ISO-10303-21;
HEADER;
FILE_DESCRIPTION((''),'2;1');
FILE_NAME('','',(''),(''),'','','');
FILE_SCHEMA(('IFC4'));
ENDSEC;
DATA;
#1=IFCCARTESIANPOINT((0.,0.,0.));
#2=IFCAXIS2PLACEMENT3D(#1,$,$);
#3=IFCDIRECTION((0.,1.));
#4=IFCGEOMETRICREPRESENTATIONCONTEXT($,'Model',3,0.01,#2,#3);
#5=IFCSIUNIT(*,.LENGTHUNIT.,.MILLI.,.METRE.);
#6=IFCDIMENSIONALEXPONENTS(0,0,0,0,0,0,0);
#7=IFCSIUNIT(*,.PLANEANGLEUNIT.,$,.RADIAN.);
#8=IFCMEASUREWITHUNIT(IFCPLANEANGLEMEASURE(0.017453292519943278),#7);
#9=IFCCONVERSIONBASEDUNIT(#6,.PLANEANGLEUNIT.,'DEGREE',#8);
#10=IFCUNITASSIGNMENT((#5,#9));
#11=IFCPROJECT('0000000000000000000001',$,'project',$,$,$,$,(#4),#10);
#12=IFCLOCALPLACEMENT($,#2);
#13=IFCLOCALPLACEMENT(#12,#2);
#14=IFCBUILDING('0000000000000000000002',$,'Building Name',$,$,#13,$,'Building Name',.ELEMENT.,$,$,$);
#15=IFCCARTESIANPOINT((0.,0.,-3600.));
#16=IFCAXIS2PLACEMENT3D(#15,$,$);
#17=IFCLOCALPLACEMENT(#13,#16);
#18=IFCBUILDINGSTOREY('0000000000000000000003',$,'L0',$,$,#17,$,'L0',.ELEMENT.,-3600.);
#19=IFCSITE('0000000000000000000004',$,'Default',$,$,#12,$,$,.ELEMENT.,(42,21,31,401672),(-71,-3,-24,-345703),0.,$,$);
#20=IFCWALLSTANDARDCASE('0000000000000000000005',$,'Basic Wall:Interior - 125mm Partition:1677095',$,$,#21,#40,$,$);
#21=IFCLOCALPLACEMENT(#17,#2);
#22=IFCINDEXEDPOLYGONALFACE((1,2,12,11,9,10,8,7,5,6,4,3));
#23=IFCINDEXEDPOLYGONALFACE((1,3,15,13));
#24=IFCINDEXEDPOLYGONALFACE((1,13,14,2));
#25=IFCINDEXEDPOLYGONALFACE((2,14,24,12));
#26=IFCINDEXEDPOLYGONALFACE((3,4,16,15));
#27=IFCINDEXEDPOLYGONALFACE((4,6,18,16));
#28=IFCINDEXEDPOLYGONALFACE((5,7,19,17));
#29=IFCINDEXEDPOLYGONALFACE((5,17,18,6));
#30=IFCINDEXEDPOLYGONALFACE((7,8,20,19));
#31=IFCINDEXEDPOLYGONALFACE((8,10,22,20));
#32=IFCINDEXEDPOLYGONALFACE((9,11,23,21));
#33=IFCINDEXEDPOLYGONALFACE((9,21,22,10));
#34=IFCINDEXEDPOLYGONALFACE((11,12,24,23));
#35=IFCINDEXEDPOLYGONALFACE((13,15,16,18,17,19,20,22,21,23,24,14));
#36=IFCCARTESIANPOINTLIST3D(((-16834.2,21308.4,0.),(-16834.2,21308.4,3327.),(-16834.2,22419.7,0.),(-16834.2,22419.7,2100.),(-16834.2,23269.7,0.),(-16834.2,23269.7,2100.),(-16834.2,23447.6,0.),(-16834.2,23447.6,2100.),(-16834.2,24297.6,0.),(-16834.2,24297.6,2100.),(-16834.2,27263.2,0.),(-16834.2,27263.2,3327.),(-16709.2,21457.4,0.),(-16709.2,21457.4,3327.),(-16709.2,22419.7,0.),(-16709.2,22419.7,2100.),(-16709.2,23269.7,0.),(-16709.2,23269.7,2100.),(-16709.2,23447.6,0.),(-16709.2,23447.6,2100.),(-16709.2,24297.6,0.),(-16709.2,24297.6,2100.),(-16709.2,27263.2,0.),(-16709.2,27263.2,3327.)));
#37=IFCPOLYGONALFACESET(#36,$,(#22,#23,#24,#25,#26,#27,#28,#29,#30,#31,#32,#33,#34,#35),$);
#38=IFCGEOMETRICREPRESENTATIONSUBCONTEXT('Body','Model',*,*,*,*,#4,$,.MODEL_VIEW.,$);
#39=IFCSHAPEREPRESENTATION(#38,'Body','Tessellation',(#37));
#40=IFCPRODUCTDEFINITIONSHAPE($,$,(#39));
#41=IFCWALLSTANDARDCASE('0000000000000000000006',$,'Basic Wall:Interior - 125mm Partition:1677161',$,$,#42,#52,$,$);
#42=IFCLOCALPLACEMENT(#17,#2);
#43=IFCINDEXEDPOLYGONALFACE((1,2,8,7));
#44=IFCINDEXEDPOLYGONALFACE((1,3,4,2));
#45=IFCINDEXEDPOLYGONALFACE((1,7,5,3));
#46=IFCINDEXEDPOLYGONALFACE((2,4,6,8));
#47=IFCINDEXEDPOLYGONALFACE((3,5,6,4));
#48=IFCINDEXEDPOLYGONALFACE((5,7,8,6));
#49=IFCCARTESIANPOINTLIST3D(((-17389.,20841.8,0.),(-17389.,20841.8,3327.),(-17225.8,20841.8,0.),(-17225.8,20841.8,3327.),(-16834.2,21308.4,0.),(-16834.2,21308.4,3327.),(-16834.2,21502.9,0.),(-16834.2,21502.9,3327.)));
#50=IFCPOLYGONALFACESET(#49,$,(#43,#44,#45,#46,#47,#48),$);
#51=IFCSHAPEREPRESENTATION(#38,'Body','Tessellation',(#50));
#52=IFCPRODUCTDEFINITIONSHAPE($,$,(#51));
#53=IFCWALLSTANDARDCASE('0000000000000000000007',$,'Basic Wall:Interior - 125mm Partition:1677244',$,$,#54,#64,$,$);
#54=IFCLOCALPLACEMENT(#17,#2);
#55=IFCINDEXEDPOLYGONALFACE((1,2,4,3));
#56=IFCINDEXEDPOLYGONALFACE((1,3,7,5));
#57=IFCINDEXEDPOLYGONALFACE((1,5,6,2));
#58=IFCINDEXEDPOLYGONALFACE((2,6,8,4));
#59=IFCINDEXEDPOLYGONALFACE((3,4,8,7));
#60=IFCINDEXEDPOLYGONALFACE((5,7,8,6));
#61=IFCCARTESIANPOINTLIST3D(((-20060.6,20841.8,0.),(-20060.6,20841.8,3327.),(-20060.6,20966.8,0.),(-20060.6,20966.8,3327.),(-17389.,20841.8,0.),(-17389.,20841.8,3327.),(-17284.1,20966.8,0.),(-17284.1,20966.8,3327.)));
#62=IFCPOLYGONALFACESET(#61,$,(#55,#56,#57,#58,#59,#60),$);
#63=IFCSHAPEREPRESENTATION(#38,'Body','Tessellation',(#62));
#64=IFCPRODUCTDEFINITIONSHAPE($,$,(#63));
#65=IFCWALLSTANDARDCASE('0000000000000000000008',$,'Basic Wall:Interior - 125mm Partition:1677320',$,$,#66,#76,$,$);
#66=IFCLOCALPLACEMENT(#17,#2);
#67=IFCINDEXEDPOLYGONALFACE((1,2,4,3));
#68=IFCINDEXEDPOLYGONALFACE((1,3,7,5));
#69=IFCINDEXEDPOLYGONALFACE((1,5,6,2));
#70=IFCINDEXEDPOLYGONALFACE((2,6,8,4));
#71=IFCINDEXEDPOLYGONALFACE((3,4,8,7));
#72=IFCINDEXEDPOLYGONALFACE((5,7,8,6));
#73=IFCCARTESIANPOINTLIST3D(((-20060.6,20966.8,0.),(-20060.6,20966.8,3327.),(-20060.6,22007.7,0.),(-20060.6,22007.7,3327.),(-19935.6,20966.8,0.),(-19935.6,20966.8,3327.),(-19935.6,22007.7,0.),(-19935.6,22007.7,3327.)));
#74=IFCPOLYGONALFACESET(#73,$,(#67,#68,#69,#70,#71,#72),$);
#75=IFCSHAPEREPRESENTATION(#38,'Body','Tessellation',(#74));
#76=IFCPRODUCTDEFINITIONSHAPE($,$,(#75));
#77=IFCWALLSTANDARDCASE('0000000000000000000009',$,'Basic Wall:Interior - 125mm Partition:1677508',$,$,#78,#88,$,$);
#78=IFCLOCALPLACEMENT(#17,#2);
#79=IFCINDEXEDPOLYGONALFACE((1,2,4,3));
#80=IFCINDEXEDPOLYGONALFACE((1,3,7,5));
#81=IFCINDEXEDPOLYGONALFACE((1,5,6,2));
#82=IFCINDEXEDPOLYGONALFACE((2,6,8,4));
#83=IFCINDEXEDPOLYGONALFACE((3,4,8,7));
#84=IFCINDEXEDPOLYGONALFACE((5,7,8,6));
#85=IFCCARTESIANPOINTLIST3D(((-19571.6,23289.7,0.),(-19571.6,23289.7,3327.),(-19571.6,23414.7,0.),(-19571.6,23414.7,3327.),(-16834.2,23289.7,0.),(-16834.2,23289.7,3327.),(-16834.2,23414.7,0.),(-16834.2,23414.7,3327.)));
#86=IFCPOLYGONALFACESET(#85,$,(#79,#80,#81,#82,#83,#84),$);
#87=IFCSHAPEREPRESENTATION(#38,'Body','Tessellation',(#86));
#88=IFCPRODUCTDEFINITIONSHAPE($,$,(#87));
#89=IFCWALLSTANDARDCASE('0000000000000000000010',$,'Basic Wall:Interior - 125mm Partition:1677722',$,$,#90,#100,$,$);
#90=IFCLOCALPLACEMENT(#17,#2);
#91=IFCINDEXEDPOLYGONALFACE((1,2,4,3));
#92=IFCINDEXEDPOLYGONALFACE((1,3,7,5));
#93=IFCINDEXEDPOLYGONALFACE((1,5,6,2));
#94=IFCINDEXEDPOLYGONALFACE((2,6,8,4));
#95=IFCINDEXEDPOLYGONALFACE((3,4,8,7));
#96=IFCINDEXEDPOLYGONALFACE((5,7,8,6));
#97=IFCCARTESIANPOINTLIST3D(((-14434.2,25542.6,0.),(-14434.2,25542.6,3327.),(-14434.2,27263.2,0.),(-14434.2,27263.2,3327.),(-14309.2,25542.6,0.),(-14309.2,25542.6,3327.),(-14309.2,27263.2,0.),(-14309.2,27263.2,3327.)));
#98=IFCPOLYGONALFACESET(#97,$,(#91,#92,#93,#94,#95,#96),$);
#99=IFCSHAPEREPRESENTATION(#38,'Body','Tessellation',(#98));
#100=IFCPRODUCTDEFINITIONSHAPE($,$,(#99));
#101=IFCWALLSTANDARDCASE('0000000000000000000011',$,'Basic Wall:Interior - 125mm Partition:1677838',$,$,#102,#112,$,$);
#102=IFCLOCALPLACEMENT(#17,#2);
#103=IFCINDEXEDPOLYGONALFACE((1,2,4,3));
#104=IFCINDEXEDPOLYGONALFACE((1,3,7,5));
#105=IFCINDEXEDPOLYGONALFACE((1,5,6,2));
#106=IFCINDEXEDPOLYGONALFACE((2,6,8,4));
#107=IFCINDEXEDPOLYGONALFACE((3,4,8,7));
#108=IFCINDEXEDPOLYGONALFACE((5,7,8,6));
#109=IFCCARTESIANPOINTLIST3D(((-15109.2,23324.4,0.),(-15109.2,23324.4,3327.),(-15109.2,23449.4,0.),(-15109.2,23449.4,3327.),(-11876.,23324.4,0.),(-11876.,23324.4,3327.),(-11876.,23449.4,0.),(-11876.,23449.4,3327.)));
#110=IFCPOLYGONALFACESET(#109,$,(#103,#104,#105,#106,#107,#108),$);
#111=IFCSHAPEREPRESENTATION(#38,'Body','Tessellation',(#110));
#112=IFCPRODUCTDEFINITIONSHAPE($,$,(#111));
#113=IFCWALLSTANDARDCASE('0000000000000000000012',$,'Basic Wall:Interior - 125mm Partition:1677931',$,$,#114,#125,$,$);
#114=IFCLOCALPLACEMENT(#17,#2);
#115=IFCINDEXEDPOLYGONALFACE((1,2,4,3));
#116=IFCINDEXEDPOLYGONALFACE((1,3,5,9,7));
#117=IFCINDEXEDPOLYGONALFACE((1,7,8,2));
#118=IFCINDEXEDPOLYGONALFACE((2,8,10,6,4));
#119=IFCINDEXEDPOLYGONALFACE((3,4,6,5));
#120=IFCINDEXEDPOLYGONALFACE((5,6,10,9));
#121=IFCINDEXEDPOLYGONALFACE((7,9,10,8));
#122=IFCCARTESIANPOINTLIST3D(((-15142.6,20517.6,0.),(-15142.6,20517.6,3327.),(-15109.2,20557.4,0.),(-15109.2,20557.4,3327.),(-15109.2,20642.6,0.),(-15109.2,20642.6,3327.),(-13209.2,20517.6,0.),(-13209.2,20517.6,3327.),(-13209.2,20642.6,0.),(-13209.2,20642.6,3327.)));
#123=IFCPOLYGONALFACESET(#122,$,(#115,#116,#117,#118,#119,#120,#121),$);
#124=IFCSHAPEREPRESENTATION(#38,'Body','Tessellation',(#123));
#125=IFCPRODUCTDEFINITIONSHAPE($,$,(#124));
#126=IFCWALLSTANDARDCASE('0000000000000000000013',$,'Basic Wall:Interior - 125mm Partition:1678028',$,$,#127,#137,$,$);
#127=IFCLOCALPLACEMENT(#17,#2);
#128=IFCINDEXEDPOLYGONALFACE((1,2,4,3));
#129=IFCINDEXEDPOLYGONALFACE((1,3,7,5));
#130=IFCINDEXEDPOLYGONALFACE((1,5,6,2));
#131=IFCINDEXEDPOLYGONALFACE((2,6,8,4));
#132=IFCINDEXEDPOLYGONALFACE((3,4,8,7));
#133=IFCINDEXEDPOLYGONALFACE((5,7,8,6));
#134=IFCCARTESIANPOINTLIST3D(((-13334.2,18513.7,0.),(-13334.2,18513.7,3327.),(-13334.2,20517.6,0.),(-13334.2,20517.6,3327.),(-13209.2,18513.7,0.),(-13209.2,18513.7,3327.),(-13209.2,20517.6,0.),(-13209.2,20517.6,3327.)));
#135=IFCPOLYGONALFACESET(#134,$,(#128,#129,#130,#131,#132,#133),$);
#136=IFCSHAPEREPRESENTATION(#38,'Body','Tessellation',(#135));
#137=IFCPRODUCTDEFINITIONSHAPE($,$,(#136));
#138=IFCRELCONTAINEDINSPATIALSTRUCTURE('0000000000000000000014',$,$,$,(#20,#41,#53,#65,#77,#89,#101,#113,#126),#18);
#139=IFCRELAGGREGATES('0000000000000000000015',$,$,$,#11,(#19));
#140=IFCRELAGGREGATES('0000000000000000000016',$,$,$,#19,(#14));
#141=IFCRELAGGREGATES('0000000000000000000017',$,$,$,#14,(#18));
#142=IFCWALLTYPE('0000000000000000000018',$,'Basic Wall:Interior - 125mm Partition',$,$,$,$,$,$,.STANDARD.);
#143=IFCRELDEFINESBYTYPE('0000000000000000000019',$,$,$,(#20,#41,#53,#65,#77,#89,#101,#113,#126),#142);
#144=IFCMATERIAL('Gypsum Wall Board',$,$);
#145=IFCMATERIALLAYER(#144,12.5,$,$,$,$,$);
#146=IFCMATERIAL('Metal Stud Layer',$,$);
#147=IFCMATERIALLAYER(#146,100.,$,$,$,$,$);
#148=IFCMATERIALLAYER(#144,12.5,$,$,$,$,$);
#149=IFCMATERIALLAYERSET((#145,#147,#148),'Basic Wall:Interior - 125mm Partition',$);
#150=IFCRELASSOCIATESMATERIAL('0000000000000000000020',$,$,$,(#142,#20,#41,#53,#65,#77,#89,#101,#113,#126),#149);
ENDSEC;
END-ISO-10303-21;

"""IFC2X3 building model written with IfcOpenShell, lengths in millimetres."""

from ifc_helpers import new_model, entity, si_unit, converted_unit, direction, frame, frame_2d, origin, place, context, subcontext, project, spatial, polyline, rectangle, outline, extrude, clip, bounded_halfspace, material, layer, layer_set, layer_usage, type_object, element, save


model = new_model("IFC2X3")

# Units and contexts
model_context = context("Model", 3, precision=0.01, world=origin(), true_north=direction((0.0, 1.0)))
body_context = subcontext(model_context, "Body", "Model", "MODEL_VIEW")
ifc_project = project(units=[si_unit("LENGTHUNIT", "METRE", prefix="MILLI"), converted_unit("PLANEANGLEUNIT", "DEGREE", entity("IfcPlaneAngleMeasure", 0.017453292519943278), si_unit("PLANEANGLEUNIT", "RADIAN"), dimensions=[0, 0, 0, 0, 0, 0, 0])], contexts=[model_context])

# Site, building, storey
site_placement = place(None, origin())
site = spatial("IfcSite", under=ifc_project, at=site_placement, Name="Default", CompositionType="ELEMENT", RefLatitude=(42, 21, 31, 401672), RefLongitude=(-71, -3, -24, -345703), RefElevation=0.0)
building_placement = place(site_placement, origin())
building = spatial("IfcBuilding", under=site, at=building_placement, Name="Building Name", LongName="Building Name", CompositionType="ELEMENT")
storey_placement = place(building_placement, frame((0.0, 0.0, -3600.0)))
storey = spatial("IfcBuildingStorey", under=building, at=storey_placement, Name="L0", LongName="L0", CompositionType="ELEMENT", Elevation=-3600.0)

# Shared definitions
ifc_material_1 = material(Name="Gypsum Wall Board")

# Shared definitions
ifc_layer_1 = layer(ifc_material_1, 12.5)
ifc_material_2 = material(Name="Metal Stud Layer")
ifc_layer_2 = layer(ifc_material_2, 100.0)
ifc_layer_3 = layer(ifc_material_1, 12.5)
ifc_layer_set_1 = layer_set([ifc_layer_1, ifc_layer_2, ifc_layer_3], Name="Basic Wall:Interior - 125mm Partition")
wall_type_1 = type_object("IfcWallType", Name="Basic Wall:Interior - 125mm Partition", PredefinedType="STANDARD", material=ifc_layer_set_1)

# Wall, openings
ifc_layer_usage_1 = layer_usage(ifc_layer_set_1, "AXIS2", "NEGATIVE", 62.5)
wall_1_placement = place(storey_placement, frame((-16771.7, 27263.2, 0.0), z_axis=(0.0, 0.0, 1.0), x_axis=(0.0, -1.0, 0.0)))
wall_1 = element("IfcWallStandardCase", 1, at=wall_1_placement, inside=storey, type_object=wall_type_1, material=ifc_layer_usage_1, Name="Basic Wall:Interior - 125mm Partition:1677095", context=body_context, shape_type="Clipping", body=[
    clip(extrude(outline(polyline([(0.0, -62.5), (3848.5, -62.5), (3973.5, -62.5), (5760.3, -62.5), (5954.8, -62.5), (5805.8, 62.5), (1845.5, 62.5), (1720.5, 62.5), (0.0, 62.5), (0.0, -62.5)])), origin(), (0.0, 0.0, 1.0), 3327.0), bounded_halfspace(frame((0.0, -62.5, 3327.0), z_axis=(0.0, 0.0, -1.0), x_axis=(-1.0, 0.0, 0.0)), True, frame((0.0, -62.5, 3327.0)), polyline([(0.0, 0.0), (3848.5, 0.0), (3973.5, 0.0), (5760.3, 0.0), (5954.8, 0.0), (5805.8, 125.0), (1845.5, 125.0), (1720.5, 125.0), (0.0, 125.0), (0.0, 0.0)]))),
])
opening_1_placement = place(wall_1_placement, frame((3815.5, 62.5, 0.0)))
element("IfcOpeningElement", 2, at=opening_1_placement, cuts=wall_1, ObjectType="Opening", context=body_context, shape_type="SweptSolid", body=[
    extrude(rectangle(XDim=2100.0, YDim=850.0, at=frame_2d((1050.0, 425.0), x_axis=(1.0, 0.0))), frame((0.0, 0.0, 0.0), z_axis=(0.0, -1.0, 0.0), x_axis=(0.0, 0.0, 1.0)), (0.0, 0.0, 1.0), 125.0),
])
opening_2_placement = place(wall_1_placement, frame((4843.5, 62.5, 0.0)))
element("IfcOpeningElement", 3, at=opening_2_placement, cuts=wall_1, ObjectType="Opening", context=body_context, shape_type="SweptSolid", body=[
    extrude(rectangle(XDim=2100.0, YDim=850.0, at=frame_2d((1050.0, 425.0), x_axis=(1.0, 0.0))), frame((0.0, 0.0, 0.0), z_axis=(0.0, -1.0, 0.0), x_axis=(0.0, 0.0, 1.0)), (0.0, 0.0, 1.0), 125.0),
])

# Walls
ifc_layer_usage_2 = layer_usage(ifc_layer_set_1, "AXIS2", "NEGATIVE", 62.5)
wall_2_placement = place(storey_placement, frame((-16786.4, 21462.7, 0.0), z_axis=(0.0, 0.0, 1.0), x_axis=(-0.642788, -0.766044, 0.0)))
element("IfcWallStandardCase", 4, at=wall_2_placement, inside=storey, type_object=wall_type_1, material=ifc_layer_usage_2, Name="Basic Wall:Interior - 125mm Partition:1677161", context=body_context, shape_type="Clipping", body=[
    clip(extrude(outline(polyline([(863.0, -62.5), (758.1, 62.5), (149.0, 62.5), (0.0, -62.5), (699.8, -62.5), (863.0, -62.5)])), origin(), (0.0, 0.0, 1.0), 3327.0), bounded_halfspace(frame((0.0, -62.5, 3327.0), z_axis=(0.0, 0.0, -1.0), x_axis=(-0.766044, -0.642788, 0.0)), True, frame((0.0, -62.5, 3327.0)), polyline([(0.0, 0.0), (699.8, 0.0), (863.0, 0.0), (758.1, 125.0), (149.0, 125.0), (0.0, 0.0)]))),
])
ifc_layer_usage_3 = layer_usage(ifc_layer_set_1, "AXIS2", "NEGATIVE", 62.5)
wall_3_placement = place(storey_placement, frame((-17284.1, 20904.3, 0.0), z_axis=(0.0, 0.0, 1.0), x_axis=(-1.0, 0.0, 0.0)))
element("IfcWallStandardCase", 5, at=wall_3_placement, inside=storey, type_object=wall_type_1, material=ifc_layer_usage_3, Name="Basic Wall:Interior - 125mm Partition:1677244", context=body_context, shape_type="Clipping", body=[
    clip(extrude(outline(polyline([(2776.6, -62.5), (2776.6, 62.5), (104.9, 62.5), (0.0, -62.5), (2651.6, -62.5), (2776.6, -62.5)])), origin(), (0.0, 0.0, 1.0), 3327.0), bounded_halfspace(frame((0.0, -62.5, 3327.0), z_axis=(0.0, 0.0, -1.0), x_axis=(0.0, -1.0, 0.0)), True, frame((0.0, -62.5, 3327.0)), polyline([(0.0, 0.0), (2651.6, 0.0), (2776.6, 0.0), (2776.6, 125.0), (104.9, 125.0), (0.0, 0.0)]))),
])
ifc_layer_usage_4 = layer_usage(ifc_layer_set_1, "AXIS2", "NEGATIVE", 62.5)
wall_4_placement = place(storey_placement, frame((-19998.1, 20966.8, 0.0), z_axis=(0.0, 0.0, 1.0), x_axis=(0.0, 1.0, 0.0)))
element("IfcWallStandardCase", 6, at=wall_4_placement, inside=storey, type_object=wall_type_1, material=ifc_layer_usage_4, Name="Basic Wall:Interior - 125mm Partition:1677320", context=body_context, shape_type="Clipping", body=[
    clip(extrude(rectangle(XDim=1040.9, YDim=125.0, at=frame_2d((520.4, 0.0), x_axis=(-1.0, 0.0))), origin(), (0.0, 0.0, 1.0), 3327.0), bounded_halfspace(frame((0.0, -62.5, 3327.0), z_axis=(0.0, 0.0, -1.0), x_axis=(1.0, 0.0, 0.0)), True, frame((0.0, -62.5, 3327.0)), polyline([(0.0, 0.0), (1040.9, 0.0), (1040.9, 125.0), (0.0, 125.0), (0.0, 0.0)]))),
])
ifc_layer_usage_5 = layer_usage(ifc_layer_set_1, "AXIS2", "NEGATIVE", 62.5)
wall_5_placement = place(storey_placement, frame((-19571.6, 23352.2, 0.0)))
element("IfcWallStandardCase", 7, at=wall_5_placement, inside=storey, type_object=wall_type_1, material=ifc_layer_usage_5, Name="Basic Wall:Interior - 125mm Partition:1677508", context=body_context, shape_type="Clipping", body=[
    clip(extrude(rectangle(XDim=2737.4, YDim=125.0, at=frame_2d((1368.7, 0.0), x_axis=(-1.0, 0.0))), origin(), (0.0, 0.0, 1.0), 3327.0), bounded_halfspace(frame((0.0, -62.5, 3327.0), z_axis=(0.0, 0.0, -1.0), x_axis=(0.0, 1.0, 0.0)), True, frame((0.0, -62.5, 3327.0)), polyline([(0.0, 0.0), (2737.4, 0.0), (2737.4, 125.0), (0.0, 125.0), (0.0, 0.0)]))),
])
ifc_layer_usage_6 = layer_usage(ifc_layer_set_1, "AXIS2", "NEGATIVE", 62.5)
wall_6_placement = place(storey_placement, frame((-14371.7, 25542.6, 0.0), z_axis=(0.0, 0.0, 1.0), x_axis=(0.0, 1.0, 0.0)))
element("IfcWallStandardCase", 8, at=wall_6_placement, inside=storey, type_object=wall_type_1, material=ifc_layer_usage_6, Name="Basic Wall:Interior - 125mm Partition:1677722", context=body_context, shape_type="Clipping", body=[
    clip(extrude(rectangle(XDim=1720.5, YDim=125.0, at=frame_2d((860.3, 0.0), x_axis=(-1.0, 0.0))), origin(), (0.0, 0.0, 1.0), 3327.0), bounded_halfspace(frame((0.0, -62.5, 3327.0), z_axis=(0.0, 0.0, -1.0), x_axis=(1.0, 0.0, 0.0)), True, frame((0.0, -62.5, 3327.0)), polyline([(0.0, 0.0), (1720.5, 0.0), (1720.5, 125.0), (0.0, 125.0), (0.0, 0.0)]))),
])
ifc_layer_usage_7 = layer_usage(ifc_layer_set_1, "AXIS2", "NEGATIVE", 62.5)
wall_7_placement = place(storey_placement, frame((-15109.2, 23386.9, 0.0)))
element("IfcWallStandardCase", 9, at=wall_7_placement, inside=storey, type_object=wall_type_1, material=ifc_layer_usage_7, Name="Basic Wall:Interior - 125mm Partition:1677838", context=body_context, shape_type="Clipping", body=[
    clip(extrude(rectangle(XDim=3233.2, YDim=125.0, at=frame_2d((1616.6, 0.0), x_axis=(-1.0, 0.0))), origin(), (0.0, 0.0, 1.0), 3327.0), bounded_halfspace(frame((0.0, -62.5, 3327.0), z_axis=(0.0, 0.0, -1.0), x_axis=(0.0, 1.0, 0.0)), True, frame((0.0, -62.5, 3327.0)), polyline([(0.0, 0.0), (3233.2, 0.0), (3233.2, 125.0), (0.0, 125.0), (0.0, 0.0)]))),
])
ifc_layer_usage_8 = layer_usage(ifc_layer_set_1, "AXIS2", "NEGATIVE", 62.5)
wall_8_placement = place(storey_placement, frame((-15142.6, 20580.1, 0.0)))
element("IfcWallStandardCase", 10, at=wall_8_placement, inside=storey, type_object=wall_type_1, material=ifc_layer_usage_8, Name="Basic Wall:Interior - 125mm Partition:1677931", context=body_context, shape_type="Clipping", body=[
    clip(extrude(outline(polyline([(1933.4, -62.5), (1933.4, 62.5), (33.4, 62.5), (33.4, -22.7), (0.0, -62.5), (1808.4, -62.5), (1933.4, -62.5)])), origin(), (0.0, 0.0, 1.0), 3327.0), bounded_halfspace(frame((0.0, -62.5, 3327.0), z_axis=(0.0, 0.0, -1.0), x_axis=(0.0, 1.0, 0.0)), True, frame((0.0, -62.5, 3327.0)), polyline([(0.0, 0.0), (1808.4, 0.0), (1933.4, 0.0), (1933.4, 125.0), (33.4, 125.0), (33.4, 39.8), (0.0, 0.0)]))),
])
ifc_layer_usage_9 = layer_usage(ifc_layer_set_1, "AXIS2", "NEGATIVE", 62.5)
wall_9_placement = place(storey_placement, frame((-13271.7, 20517.6, 0.0), z_axis=(0.0, 0.0, 1.0), x_axis=(0.0, -1.0, 0.0)))
element("IfcWallStandardCase", 11, at=wall_9_placement, inside=storey, type_object=wall_type_1, material=ifc_layer_usage_9, Name="Basic Wall:Interior - 125mm Partition:1678028", context=body_context, shape_type="Clipping", body=[
    clip(extrude(rectangle(XDim=2004.0, YDim=125.0, at=frame_2d((1002.0, 0.0), x_axis=(-1.0, 0.0))), origin(), (0.0, 0.0, 1.0), 3327.0), bounded_halfspace(frame((0.0, -62.5, 3327.0), z_axis=(0.0, 0.0, -1.0), x_axis=(-1.0, 0.0, 0.0)), True, frame((0.0, -62.5, 3327.0)), polyline([(0.0, 0.0), (2004.0, 0.0), (2004.0, 125.0), (0.0, 125.0), (0.0, 0.0)]))),
])

save(model, "model.ifc")
